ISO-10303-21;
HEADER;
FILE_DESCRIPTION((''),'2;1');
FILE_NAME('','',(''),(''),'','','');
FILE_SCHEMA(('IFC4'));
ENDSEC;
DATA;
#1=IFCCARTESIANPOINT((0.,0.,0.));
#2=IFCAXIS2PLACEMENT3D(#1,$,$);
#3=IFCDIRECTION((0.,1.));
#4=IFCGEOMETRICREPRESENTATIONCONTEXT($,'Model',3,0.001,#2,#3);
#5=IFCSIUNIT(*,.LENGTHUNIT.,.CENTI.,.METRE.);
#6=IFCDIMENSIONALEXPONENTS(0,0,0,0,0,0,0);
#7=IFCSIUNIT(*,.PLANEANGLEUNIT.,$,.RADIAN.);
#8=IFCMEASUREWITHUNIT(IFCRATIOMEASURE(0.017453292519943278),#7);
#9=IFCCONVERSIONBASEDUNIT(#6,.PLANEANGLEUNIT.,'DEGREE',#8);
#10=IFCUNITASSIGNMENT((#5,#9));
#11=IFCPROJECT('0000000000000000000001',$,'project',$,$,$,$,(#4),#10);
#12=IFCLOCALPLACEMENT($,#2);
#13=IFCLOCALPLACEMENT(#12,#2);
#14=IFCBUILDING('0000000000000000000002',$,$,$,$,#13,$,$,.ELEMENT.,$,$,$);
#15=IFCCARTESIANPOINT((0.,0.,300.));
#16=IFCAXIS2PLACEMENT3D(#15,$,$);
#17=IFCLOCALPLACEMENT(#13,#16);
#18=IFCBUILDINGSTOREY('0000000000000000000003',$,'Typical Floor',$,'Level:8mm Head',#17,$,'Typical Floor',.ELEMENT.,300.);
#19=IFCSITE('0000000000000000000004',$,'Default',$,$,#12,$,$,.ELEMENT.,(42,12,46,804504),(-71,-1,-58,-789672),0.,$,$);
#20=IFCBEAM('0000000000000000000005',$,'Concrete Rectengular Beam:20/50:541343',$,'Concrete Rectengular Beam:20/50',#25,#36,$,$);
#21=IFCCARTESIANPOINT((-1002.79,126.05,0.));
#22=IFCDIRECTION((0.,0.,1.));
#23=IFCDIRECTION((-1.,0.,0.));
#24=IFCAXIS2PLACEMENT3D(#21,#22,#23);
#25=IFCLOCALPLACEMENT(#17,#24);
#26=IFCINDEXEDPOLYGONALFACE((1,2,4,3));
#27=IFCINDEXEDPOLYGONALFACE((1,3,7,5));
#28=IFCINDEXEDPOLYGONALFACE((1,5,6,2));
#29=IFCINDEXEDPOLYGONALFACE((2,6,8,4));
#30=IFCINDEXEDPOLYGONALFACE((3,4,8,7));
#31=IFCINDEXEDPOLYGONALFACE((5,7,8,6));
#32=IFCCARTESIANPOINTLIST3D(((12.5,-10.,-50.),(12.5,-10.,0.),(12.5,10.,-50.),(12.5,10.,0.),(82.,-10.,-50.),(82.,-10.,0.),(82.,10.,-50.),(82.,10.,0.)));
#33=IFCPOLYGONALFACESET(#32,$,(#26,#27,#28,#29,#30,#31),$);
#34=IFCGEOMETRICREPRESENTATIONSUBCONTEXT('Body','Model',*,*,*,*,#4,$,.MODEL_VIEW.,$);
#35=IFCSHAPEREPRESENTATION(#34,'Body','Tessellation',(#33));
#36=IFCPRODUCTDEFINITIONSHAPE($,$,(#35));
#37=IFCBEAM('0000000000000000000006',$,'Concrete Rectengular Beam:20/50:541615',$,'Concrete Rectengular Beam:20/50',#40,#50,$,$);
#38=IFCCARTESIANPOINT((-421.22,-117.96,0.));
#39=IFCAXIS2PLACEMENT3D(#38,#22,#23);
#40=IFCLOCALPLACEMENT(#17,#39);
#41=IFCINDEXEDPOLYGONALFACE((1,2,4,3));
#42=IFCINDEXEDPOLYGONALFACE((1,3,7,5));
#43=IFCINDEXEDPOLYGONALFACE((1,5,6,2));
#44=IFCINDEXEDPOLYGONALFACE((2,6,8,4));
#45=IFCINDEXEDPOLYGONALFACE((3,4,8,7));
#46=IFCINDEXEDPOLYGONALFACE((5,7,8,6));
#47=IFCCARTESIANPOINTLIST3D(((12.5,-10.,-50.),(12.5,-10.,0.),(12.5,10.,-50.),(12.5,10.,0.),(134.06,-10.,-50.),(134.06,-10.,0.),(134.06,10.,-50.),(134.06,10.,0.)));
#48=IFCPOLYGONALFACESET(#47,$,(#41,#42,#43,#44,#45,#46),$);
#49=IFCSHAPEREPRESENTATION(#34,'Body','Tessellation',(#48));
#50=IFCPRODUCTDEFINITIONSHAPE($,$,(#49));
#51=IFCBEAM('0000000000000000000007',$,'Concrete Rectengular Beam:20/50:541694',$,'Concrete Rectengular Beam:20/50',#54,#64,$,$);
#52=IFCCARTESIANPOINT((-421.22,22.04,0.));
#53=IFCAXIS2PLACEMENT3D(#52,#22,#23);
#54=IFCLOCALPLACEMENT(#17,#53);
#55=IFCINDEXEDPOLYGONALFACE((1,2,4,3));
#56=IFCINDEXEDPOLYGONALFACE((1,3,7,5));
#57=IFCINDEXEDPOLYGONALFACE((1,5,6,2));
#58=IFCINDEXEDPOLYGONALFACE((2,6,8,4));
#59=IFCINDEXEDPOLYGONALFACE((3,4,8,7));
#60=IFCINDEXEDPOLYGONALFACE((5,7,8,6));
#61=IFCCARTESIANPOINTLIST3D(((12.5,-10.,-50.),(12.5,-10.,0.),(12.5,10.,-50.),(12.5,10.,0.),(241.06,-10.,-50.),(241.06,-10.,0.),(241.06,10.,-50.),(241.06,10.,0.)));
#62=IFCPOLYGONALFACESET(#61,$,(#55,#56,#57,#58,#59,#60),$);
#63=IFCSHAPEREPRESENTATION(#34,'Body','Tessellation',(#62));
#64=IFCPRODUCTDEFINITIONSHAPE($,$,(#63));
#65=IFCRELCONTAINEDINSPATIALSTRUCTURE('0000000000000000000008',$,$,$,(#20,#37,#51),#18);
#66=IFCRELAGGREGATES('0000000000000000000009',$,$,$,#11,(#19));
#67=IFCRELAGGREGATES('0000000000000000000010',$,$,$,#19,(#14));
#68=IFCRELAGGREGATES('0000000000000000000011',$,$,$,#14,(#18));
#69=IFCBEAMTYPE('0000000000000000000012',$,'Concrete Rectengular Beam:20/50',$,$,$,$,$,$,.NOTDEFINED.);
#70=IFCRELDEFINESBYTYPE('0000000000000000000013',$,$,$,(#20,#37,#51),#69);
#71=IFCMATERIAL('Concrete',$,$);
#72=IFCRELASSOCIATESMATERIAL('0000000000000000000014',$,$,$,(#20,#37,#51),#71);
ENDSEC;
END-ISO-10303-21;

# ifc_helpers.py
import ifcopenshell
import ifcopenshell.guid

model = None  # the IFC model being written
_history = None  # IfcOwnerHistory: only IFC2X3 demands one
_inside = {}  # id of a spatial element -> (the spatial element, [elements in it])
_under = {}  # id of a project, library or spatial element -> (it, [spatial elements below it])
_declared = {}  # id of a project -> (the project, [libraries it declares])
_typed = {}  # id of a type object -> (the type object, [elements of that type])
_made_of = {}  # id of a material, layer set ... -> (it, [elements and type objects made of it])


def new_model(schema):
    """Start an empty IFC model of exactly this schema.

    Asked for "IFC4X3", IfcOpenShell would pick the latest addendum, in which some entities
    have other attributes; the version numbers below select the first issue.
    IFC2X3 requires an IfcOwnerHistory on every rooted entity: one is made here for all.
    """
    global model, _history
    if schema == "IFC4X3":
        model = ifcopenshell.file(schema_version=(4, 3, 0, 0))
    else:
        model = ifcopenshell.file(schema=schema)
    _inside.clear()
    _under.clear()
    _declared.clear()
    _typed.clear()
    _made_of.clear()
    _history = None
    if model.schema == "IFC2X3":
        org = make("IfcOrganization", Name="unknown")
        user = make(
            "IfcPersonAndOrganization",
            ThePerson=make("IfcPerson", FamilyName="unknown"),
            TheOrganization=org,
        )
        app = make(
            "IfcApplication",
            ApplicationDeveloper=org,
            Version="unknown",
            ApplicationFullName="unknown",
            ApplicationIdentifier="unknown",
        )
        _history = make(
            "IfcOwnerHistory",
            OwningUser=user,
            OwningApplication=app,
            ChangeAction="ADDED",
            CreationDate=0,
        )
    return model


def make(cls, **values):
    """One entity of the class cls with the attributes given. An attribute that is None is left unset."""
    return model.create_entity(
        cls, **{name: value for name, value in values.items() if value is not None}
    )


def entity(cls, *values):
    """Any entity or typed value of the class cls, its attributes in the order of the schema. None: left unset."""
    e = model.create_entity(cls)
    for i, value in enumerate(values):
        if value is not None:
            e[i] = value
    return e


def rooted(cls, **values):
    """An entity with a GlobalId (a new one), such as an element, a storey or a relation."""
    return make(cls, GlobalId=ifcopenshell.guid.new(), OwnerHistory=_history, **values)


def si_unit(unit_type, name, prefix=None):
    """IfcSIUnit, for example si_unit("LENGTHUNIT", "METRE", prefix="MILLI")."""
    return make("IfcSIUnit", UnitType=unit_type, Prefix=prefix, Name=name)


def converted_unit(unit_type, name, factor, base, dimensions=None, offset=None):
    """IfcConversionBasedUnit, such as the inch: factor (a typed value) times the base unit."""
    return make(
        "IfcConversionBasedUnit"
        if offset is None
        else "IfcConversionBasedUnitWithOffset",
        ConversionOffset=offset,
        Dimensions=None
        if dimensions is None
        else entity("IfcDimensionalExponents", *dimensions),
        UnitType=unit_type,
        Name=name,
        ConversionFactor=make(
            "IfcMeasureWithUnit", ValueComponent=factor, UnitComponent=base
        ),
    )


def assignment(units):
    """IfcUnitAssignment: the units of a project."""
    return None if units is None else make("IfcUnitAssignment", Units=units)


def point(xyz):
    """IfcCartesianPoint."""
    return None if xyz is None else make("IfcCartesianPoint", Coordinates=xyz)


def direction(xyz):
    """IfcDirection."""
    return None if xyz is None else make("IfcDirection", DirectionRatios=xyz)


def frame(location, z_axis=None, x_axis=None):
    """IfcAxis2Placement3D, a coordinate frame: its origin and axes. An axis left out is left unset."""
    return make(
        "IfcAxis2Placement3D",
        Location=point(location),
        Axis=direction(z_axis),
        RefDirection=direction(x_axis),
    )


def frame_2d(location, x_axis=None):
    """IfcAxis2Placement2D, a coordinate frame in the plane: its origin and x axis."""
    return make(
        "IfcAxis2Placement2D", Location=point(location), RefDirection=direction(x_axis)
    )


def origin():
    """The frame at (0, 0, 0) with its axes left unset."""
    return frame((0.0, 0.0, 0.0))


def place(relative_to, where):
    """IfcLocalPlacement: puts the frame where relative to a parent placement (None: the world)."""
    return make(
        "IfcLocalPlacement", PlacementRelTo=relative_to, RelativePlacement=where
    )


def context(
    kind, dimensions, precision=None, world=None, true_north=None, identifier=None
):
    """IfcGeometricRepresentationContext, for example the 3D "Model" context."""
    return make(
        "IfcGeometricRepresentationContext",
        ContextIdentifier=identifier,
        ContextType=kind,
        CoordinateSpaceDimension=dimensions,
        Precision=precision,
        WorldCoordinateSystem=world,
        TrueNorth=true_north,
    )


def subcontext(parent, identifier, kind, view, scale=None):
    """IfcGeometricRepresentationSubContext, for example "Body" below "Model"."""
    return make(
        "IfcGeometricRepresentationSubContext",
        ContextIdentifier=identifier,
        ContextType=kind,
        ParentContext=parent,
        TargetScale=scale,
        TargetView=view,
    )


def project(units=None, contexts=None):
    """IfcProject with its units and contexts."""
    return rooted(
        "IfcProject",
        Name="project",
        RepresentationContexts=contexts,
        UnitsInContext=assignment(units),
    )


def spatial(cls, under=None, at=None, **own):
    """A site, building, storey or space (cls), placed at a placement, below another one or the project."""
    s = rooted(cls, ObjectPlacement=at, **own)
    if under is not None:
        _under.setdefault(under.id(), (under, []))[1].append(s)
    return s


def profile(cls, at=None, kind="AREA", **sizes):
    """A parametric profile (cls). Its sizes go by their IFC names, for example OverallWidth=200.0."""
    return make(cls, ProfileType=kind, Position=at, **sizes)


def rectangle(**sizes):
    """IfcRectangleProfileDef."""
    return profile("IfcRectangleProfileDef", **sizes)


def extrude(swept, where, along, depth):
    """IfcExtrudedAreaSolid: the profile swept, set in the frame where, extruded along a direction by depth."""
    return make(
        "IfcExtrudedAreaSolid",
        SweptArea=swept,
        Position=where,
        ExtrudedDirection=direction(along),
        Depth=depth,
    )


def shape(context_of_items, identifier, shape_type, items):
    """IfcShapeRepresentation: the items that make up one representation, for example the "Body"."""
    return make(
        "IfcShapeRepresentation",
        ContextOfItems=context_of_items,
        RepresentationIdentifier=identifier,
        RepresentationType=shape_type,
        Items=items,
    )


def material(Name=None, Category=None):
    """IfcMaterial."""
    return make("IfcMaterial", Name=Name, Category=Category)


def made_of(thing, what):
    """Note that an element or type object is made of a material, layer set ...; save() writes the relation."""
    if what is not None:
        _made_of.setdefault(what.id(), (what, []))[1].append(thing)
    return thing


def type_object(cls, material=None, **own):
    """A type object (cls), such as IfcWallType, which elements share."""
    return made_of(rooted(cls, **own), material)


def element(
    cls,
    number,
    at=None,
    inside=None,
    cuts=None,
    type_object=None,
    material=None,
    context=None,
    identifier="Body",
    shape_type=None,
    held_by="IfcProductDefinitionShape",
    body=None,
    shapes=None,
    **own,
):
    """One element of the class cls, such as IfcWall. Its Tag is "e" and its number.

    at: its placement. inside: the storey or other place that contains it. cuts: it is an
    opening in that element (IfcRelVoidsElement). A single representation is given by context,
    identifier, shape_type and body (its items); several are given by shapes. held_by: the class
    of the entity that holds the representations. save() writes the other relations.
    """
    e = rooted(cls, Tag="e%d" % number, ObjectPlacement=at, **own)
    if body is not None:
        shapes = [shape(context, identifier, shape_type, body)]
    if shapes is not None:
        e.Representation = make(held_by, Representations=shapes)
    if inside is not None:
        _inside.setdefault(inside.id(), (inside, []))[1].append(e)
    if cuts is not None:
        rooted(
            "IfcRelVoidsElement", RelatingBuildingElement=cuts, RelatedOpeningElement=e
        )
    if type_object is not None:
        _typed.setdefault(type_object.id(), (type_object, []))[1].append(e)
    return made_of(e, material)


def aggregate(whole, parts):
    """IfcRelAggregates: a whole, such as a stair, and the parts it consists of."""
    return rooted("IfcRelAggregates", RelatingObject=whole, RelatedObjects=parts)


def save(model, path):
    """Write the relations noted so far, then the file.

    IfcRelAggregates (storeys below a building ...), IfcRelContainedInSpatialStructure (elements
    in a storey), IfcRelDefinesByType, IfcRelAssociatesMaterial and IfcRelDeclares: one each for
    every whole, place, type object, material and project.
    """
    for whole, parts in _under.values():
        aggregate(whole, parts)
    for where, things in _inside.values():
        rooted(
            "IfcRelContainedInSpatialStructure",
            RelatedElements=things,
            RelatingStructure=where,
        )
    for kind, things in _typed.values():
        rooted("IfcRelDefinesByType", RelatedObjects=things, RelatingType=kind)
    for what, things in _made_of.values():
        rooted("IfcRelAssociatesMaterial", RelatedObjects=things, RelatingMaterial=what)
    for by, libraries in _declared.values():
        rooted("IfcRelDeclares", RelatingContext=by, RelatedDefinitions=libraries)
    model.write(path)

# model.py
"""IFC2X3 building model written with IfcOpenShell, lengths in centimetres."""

from ifc_helpers import new_model, entity, si_unit, converted_unit, direction, frame, frame_2d, origin, place, context, subcontext, project, spatial, rectangle, extrude, material, type_object, element, save


model = new_model("IFC2X3")

# Units and contexts
model_context = context("Model", 3, precision=0.001, world=origin(), true_north=direction((0.0, 1.0)))
body_context = subcontext(model_context, "Body", "Model", "MODEL_VIEW")
ifc_project = project(units=[si_unit("LENGTHUNIT", "METRE", prefix="CENTI"), converted_unit("PLANEANGLEUNIT", "DEGREE", entity("IfcRatioMeasure", 0.017453292519943278), si_unit("PLANEANGLEUNIT", "RADIAN"), dimensions=[0, 0, 0, 0, 0, 0, 0])], contexts=[model_context])

# Site, building, storey
site_placement = place(None, origin())
site = spatial("IfcSite", under=ifc_project, at=site_placement, Name="Default", CompositionType="ELEMENT", RefLatitude=(42, 12, 46, 804504), RefLongitude=(-71, -1, -58, -789672), RefElevation=0.0)
building_placement = place(site_placement, origin())
building = spatial("IfcBuilding", under=site, at=building_placement, CompositionType="ELEMENT")
storey_placement = place(building_placement, frame((0.0, 0.0, 300.0)))
storey = spatial("IfcBuildingStorey", under=building, at=storey_placement, Name="Typical Floor", ObjectType="Level:8mm Head", LongName="Typical Floor", CompositionType="ELEMENT", Elevation=300.0)

# Beams
ifc_material = material(Name="Concrete")
beam_type_1 = type_object("IfcBeamType", Name="Concrete Rectengular Beam:20/50", PredefinedType="NOTDEFINED")
beam_1_placement = place(storey_placement, frame((-1002.79, 126.05, 0.0), z_axis=(0.0, 0.0, 1.0), x_axis=(-1.0, 0.0, 0.0)))
element("IfcBeam", 1, at=beam_1_placement, inside=storey, type_object=beam_type_1, material=ifc_material, Name="Concrete Rectengular Beam:20/50:541343", ObjectType="Concrete Rectengular Beam:20/50", context=body_context, shape_type="SweptSolid", body=[
    extrude(rectangle(XDim=50.0, YDim=20.0, at=frame_2d((0.0, 0.0), x_axis=(1.0, 0.0))), frame((12.5, 0.0, -25.0), z_axis=(1.0, 0.0, 0.0), x_axis=(0.0, 0.0, -1.0)), (0.0, 0.0, 1.0), 69.5),
])
beam_2_placement = place(storey_placement, frame((-421.22, -117.96, 0.0), z_axis=(0.0, 0.0, 1.0), x_axis=(-1.0, 0.0, 0.0)))
element("IfcBeam", 2, at=beam_2_placement, inside=storey, type_object=beam_type_1, material=ifc_material, Name="Concrete Rectengular Beam:20/50:541615", ObjectType="Concrete Rectengular Beam:20/50", context=body_context, shape_type="SweptSolid", body=[
    extrude(rectangle(XDim=50.0, YDim=20.0, at=frame_2d((0.0, 0.0), x_axis=(1.0, 0.0))), frame((12.5, 0.0, -25.0), z_axis=(1.0, 0.0, 0.0), x_axis=(0.0, 0.0, -1.0)), (0.0, 0.0, 1.0), 121.56),
])
beam_3_placement = place(storey_placement, frame((-421.22, 22.04, 0.0), z_axis=(0.0, 0.0, 1.0), x_axis=(-1.0, 0.0, 0.0)))
element("IfcBeam", 3, at=beam_3_placement, inside=storey, type_object=beam_type_1, material=ifc_material, Name="Concrete Rectengular Beam:20/50:541694", ObjectType="Concrete Rectengular Beam:20/50", context=body_context, shape_type="SweptSolid", body=[
    extrude(rectangle(XDim=50.0, YDim=20.0, at=frame_2d((0.0, 0.0), x_axis=(1.0, 0.0))), frame((12.5, 0.0, -25.0), z_axis=(1.0, 0.0, 0.0), x_axis=(0.0, 0.0, -1.0)), (0.0, 0.0, 1.0), 228.56),
])

save(model, "model.ifc")
